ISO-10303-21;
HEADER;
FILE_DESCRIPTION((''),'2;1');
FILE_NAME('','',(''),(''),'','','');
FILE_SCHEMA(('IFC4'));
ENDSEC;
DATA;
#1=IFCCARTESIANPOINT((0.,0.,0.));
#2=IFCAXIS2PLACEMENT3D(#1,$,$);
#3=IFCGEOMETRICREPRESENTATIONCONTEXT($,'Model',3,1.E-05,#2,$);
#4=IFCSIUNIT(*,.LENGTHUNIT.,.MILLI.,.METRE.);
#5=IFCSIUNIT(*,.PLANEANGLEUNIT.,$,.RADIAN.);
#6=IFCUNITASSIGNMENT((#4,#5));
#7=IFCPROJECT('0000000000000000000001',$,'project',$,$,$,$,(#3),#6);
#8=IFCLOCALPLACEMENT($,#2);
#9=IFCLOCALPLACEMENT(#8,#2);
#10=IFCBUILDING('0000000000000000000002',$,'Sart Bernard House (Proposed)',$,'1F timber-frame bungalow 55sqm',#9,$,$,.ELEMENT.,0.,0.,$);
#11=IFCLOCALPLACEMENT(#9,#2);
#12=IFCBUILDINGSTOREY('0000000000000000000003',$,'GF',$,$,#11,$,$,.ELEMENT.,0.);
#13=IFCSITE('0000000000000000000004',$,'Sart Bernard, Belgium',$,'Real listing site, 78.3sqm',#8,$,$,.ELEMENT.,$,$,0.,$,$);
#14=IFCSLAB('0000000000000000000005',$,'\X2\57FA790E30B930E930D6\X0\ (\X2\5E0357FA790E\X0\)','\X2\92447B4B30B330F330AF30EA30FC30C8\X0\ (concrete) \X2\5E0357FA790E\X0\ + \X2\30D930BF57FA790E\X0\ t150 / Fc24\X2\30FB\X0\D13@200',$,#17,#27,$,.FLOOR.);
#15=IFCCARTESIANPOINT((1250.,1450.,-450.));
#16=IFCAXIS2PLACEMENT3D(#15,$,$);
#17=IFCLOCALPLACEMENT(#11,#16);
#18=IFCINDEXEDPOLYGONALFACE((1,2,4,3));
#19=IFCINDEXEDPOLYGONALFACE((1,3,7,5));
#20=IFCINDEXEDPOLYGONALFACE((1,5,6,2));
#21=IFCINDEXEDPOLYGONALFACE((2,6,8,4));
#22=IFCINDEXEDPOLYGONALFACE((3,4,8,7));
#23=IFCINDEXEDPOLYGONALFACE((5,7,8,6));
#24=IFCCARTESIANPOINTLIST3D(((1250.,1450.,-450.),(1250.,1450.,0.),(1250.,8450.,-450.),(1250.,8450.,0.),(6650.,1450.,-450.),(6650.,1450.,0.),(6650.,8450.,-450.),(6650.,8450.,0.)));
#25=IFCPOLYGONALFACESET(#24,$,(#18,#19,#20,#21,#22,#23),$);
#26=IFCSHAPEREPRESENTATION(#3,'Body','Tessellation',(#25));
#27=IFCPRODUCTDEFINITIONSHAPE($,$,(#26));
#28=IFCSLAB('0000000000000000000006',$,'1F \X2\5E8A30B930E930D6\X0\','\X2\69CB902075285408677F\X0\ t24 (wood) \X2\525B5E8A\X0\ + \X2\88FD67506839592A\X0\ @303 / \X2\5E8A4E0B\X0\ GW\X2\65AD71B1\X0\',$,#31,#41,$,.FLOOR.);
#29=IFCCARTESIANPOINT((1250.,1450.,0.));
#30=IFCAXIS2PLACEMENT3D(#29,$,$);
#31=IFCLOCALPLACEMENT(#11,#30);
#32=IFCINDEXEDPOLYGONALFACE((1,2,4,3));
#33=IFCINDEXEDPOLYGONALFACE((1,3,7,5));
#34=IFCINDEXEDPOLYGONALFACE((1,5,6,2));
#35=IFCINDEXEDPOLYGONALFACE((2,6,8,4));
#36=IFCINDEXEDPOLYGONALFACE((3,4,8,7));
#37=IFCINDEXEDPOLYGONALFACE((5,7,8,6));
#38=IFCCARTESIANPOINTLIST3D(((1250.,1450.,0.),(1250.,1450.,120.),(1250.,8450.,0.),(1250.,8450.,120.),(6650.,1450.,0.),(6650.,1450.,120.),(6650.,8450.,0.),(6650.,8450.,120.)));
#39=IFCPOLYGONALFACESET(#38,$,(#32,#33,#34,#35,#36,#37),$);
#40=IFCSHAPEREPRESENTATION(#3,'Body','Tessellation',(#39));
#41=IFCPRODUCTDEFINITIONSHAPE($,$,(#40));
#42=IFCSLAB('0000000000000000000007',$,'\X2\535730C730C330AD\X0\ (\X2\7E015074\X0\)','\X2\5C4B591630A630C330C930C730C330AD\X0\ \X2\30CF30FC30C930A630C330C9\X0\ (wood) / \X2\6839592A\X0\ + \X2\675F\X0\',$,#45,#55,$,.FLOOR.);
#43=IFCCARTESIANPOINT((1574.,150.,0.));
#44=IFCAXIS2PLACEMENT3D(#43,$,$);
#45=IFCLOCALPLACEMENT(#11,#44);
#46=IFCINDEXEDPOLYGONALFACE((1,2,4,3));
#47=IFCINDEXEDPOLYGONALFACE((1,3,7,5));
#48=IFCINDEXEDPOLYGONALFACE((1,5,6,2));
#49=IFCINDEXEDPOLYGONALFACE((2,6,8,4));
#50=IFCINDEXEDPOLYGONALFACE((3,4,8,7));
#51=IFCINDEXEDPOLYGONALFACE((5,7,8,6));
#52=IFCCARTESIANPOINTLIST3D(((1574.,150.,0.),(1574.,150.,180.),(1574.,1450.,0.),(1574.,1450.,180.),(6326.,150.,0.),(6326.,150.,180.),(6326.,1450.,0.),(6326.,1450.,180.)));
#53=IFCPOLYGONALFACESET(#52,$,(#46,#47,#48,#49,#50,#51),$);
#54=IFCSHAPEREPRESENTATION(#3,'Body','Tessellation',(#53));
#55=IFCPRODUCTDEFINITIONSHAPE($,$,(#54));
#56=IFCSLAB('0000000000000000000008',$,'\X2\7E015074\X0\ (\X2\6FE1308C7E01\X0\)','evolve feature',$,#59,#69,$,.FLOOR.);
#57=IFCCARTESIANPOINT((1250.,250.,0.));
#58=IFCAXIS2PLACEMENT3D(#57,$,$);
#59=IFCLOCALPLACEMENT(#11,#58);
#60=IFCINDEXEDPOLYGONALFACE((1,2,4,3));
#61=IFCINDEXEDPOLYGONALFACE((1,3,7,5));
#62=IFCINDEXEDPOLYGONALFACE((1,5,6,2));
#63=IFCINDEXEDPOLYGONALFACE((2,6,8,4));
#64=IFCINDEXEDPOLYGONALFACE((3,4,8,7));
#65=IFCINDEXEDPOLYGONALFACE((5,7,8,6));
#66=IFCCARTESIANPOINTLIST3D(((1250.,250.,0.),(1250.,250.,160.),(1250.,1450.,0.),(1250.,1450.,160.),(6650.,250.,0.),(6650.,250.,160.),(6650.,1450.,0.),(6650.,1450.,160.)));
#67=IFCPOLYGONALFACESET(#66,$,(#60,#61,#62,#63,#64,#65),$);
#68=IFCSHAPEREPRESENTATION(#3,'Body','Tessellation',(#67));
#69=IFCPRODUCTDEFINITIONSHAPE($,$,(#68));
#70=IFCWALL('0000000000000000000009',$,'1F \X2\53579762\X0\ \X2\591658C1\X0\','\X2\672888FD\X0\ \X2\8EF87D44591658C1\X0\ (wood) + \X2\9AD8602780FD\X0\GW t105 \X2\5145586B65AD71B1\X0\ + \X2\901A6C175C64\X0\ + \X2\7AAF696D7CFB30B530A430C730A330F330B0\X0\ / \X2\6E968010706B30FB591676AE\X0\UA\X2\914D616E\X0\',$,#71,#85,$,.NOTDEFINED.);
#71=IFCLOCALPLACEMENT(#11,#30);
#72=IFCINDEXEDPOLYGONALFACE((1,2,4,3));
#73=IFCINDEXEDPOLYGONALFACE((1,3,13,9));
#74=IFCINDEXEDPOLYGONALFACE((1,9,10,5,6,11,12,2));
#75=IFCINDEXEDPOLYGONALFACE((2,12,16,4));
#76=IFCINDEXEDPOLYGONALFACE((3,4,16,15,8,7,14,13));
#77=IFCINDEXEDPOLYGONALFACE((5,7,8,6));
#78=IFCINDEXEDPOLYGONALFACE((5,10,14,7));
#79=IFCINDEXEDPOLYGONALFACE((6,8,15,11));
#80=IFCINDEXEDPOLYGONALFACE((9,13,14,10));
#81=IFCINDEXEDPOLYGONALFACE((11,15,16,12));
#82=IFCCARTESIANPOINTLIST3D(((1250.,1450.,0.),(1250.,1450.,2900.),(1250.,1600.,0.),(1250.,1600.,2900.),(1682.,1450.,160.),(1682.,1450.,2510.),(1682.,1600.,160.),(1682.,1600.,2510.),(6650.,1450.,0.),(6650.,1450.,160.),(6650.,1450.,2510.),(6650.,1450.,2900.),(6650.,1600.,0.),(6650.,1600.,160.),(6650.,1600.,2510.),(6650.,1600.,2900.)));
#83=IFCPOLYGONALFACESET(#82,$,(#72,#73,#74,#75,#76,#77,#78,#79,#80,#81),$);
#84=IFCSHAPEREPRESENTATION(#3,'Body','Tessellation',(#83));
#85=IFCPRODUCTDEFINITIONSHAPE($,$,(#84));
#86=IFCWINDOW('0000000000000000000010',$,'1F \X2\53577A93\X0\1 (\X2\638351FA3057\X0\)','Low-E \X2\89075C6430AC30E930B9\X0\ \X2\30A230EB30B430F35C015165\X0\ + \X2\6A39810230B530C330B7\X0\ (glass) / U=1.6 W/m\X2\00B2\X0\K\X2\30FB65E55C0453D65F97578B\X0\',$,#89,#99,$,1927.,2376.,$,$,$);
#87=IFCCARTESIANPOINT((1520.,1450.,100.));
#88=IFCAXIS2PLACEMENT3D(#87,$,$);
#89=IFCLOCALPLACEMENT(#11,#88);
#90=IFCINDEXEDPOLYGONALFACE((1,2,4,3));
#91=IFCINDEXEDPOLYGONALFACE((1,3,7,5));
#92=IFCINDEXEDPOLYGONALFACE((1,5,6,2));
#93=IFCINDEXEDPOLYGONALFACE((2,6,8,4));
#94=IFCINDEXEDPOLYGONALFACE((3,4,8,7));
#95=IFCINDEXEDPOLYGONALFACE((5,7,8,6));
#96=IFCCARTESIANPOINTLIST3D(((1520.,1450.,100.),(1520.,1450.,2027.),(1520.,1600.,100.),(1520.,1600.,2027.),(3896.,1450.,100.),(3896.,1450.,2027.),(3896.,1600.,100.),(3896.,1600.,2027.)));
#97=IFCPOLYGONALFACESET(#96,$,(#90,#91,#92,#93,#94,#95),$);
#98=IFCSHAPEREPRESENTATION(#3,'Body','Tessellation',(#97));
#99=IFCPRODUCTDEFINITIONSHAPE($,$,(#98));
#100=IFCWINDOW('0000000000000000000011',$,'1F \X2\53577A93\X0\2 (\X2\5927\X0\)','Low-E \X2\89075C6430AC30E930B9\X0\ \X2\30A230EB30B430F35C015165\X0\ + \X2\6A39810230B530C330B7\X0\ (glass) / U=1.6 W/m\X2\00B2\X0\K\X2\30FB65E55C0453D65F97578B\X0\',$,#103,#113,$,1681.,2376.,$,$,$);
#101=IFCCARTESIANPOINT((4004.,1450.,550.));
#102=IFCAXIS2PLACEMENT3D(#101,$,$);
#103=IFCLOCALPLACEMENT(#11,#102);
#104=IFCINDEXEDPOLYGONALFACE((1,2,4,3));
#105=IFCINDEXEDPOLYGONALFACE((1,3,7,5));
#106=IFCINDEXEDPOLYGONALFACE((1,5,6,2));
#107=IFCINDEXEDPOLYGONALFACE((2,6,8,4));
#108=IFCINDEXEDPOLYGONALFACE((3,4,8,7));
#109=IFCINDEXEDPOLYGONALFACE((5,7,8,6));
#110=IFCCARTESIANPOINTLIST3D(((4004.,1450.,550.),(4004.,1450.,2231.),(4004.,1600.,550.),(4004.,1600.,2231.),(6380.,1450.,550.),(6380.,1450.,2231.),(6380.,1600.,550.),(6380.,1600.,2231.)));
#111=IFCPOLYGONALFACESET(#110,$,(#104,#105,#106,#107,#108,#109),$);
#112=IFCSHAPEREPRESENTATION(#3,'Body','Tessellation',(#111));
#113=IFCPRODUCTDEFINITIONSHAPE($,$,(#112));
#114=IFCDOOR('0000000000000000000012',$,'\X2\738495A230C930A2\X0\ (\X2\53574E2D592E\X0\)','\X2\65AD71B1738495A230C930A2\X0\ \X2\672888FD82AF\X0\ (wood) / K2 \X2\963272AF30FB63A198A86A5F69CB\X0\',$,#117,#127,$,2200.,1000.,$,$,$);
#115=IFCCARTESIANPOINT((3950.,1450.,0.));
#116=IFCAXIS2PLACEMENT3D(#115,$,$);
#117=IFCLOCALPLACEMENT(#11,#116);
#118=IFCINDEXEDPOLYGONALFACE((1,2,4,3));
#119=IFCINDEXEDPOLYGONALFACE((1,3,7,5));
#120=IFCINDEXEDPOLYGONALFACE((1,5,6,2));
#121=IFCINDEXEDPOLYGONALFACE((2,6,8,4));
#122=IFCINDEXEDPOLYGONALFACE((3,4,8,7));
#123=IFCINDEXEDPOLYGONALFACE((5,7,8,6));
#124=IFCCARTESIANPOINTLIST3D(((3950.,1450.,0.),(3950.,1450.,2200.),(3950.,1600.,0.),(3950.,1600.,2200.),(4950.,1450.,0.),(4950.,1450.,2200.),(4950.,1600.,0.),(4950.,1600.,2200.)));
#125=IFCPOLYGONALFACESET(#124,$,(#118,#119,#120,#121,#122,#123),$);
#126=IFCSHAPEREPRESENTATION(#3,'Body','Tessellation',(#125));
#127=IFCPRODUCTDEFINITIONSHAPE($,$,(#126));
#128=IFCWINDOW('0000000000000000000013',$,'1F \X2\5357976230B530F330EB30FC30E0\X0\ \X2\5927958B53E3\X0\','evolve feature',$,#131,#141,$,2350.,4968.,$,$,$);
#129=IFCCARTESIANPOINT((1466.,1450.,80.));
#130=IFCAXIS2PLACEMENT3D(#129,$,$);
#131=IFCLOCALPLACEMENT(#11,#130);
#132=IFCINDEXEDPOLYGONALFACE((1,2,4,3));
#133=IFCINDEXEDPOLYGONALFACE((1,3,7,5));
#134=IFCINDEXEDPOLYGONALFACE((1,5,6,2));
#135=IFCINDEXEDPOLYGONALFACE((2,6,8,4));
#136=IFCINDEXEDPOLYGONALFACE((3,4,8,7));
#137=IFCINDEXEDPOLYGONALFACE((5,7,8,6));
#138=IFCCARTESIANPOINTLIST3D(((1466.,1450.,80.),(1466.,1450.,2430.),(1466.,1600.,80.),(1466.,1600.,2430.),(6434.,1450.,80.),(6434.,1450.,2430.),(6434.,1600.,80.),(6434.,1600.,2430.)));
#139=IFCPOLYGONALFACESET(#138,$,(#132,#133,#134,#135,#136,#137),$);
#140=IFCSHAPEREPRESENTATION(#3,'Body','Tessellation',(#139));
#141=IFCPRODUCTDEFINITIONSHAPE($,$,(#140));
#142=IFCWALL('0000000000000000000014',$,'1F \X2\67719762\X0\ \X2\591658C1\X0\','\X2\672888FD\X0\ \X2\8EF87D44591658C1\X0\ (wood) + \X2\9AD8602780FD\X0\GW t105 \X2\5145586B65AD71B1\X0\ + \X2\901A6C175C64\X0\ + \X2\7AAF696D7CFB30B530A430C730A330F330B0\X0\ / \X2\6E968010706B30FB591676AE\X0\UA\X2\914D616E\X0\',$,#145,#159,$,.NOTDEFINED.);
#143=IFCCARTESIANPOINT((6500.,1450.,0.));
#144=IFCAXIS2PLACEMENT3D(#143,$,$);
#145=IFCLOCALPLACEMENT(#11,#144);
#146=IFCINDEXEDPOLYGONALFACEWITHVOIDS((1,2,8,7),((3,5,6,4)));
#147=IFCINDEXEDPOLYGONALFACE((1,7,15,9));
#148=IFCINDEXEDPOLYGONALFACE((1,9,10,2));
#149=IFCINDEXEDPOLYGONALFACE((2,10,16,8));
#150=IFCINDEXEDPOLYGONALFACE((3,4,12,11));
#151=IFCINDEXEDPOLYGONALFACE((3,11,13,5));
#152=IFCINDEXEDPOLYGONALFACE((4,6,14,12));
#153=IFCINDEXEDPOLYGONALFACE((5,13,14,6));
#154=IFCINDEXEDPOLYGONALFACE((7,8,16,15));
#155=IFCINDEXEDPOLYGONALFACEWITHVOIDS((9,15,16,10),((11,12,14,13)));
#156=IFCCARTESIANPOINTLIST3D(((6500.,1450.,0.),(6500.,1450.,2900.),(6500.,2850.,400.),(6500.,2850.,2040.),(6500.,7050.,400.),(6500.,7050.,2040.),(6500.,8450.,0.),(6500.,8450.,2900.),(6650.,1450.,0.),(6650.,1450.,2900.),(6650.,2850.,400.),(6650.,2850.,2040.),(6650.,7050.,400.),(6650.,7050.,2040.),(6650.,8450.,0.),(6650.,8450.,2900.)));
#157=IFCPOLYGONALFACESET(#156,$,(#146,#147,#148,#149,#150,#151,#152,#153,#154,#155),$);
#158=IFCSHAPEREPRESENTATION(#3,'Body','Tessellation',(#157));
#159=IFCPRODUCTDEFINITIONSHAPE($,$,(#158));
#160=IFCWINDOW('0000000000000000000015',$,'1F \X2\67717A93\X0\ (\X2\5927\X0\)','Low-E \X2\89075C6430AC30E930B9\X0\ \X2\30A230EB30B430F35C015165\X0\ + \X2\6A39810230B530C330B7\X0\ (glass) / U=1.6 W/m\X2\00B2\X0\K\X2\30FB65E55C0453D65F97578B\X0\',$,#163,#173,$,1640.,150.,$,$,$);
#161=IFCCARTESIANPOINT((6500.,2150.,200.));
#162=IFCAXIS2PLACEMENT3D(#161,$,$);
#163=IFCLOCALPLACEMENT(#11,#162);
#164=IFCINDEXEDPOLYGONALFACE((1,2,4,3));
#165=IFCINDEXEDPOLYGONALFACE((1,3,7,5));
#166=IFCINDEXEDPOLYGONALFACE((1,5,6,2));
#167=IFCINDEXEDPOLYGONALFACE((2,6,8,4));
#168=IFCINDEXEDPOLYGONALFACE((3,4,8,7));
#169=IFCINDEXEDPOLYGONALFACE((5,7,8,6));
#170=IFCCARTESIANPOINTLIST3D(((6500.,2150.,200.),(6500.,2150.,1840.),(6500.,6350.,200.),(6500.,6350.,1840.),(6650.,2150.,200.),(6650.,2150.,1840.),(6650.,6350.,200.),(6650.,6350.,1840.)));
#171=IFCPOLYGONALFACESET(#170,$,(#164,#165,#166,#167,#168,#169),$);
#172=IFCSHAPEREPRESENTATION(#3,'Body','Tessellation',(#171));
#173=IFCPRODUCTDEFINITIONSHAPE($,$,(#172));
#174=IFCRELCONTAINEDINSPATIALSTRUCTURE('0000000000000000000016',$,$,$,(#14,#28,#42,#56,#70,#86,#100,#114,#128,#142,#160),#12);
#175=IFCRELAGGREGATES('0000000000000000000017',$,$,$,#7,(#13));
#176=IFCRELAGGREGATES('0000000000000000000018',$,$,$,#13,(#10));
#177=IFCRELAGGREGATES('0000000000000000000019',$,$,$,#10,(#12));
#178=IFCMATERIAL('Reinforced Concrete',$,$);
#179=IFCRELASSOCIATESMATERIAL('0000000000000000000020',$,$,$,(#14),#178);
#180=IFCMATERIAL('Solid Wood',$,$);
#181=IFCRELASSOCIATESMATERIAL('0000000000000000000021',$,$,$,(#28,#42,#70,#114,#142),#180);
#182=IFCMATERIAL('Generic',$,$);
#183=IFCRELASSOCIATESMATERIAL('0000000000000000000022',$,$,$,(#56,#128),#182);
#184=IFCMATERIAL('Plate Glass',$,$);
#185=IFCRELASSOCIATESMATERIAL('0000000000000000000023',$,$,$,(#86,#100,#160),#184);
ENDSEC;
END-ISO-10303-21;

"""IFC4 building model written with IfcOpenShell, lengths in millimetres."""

from ifc_helpers import new_model, si_unit, frame, frame_2d, origin, place, context, project, spatial, rectangle, extrude, material, element, fill, save


model = new_model("IFC4")

# Units and contexts
model_context = context("Model", 3, precision=1e-05, world=origin())
ifc_project = project(units=[si_unit("LENGTHUNIT", "METRE", prefix="MILLI"), si_unit("PLANEANGLEUNIT", "RADIAN")], contexts=[model_context])

# Site, building, storey
site_placement = place(None, origin())
site = spatial("IfcSite", under=ifc_project, at=site_placement, Name="Sart Bernard, Belgium", ObjectType="Real listing site, 78.3sqm", CompositionType="ELEMENT", RefElevation=0.0)
building_placement = place(site_placement, origin())
building = spatial("IfcBuilding", under=site, at=building_placement, Name="Sart Bernard House (Proposed)", ObjectType="1F timber-frame bungalow 55sqm", CompositionType="ELEMENT", ElevationOfRefHeight=0.0, ElevationOfTerrain=0.0)
storey_placement = place(building_placement, origin())
storey = spatial("IfcBuildingStorey", under=building, at=storey_placement, Name="GF", CompositionType="ELEMENT", Elevation=0.0)

# Slabs
ifc_material_1 = material(Name="Reinforced Concrete")
slab_1_placement = place(storey_placement, frame((1250.0, 1450.0, -450.0)))
element("IfcSlab", 1, at=slab_1_placement, inside=storey, material=ifc_material_1, Name="基礎スラブ (布基礎)", Description="鉄筋コンクリート (concrete) 布基礎 + ベタ基礎 t150 / Fc24・D13@200", PredefinedType="FLOOR", context=model_context, shape_type="SweptSolid", body=[
    extrude(rectangle(XDim=5400.0, YDim=7000.0, at=frame_2d((2700.0, 3500.0))), frame((1250.0, 1450.0, -450.0)), (0.0, 0.0, 1.0), 450.0),
])
ifc_material_2 = material(Name="Solid Wood")
slab_2_placement = place(storey_placement, frame((1250.0, 1450.0, 0.0)))
element("IfcSlab", 2, at=slab_2_placement, inside=storey, material=ifc_material_2, Name="1F 床スラブ", Description="構造用合板 t24 (wood) 剛床 + 製材根太 @303 / 床下 GW断熱", PredefinedType="FLOOR", context=model_context, shape_type="SweptSolid", body=[
    extrude(rectangle(XDim=5400.0, YDim=7000.0, at=frame_2d((2700.0, 3500.0))), frame((1250.0, 1450.0, 0.0)), (0.0, 0.0, 1.0), 120.0),
])
slab_3_placement = place(storey_placement, frame((1574.0, 150.0, 0.0)))
element("IfcSlab", 3, at=slab_3_placement, inside=storey, material=ifc_material_2, Name="南デッキ (縁側)", Description="屋外ウッドデッキ ハードウッド (wood) / 根太 + 束", PredefinedType="FLOOR", context=model_context, shape_type="SweptSolid", body=[
    extrude(rectangle(XDim=4752.0, YDim=1300.0, at=frame_2d((2376.0, 650.0))), frame((1574.0, 150.0, 0.0)), (0.0, 0.0, 1.0), 180.0),
])
ifc_material_3 = material(Name="Generic")
slab_4_placement = place(storey_placement, frame((1250.0, 250.0, 0.0)))
element("IfcSlab", 4, at=slab_4_placement, inside=storey, material=ifc_material_3, Name="縁側 (濡れ縁)", Description="evolve feature", PredefinedType="FLOOR", context=model_context, shape_type="SweptSolid", body=[
    extrude(rectangle(XDim=5400.0, YDim=1200.0, at=frame_2d((2700.0, 600.0))), frame((1250.0, 250.0, 0.0)), (0.0, 0.0, 1.0), 160.0),
])

# Wall, openings, windows, door
wall_1_placement = place(storey_placement, frame((1250.0, 1450.0, 0.0)))
wall_1 = element("IfcWall", 5, at=wall_1_placement, inside=storey, material=ifc_material_2, Name="1F 南面 外壁", Description="木製 軸組外壁 (wood) + 高性能GW t105 充填断熱 + 通気層 + 窯業系サイディング / 準耐火・外皮UA配慮", PredefinedType="NOTDEFINED", context=model_context, shape_type="SweptSolid", body=[
    extrude(rectangle(XDim=5400.0, YDim=150.0, at=frame_2d((2700.0, 75.0))), frame((1250.0, 1450.0, 0.0)), (0.0, 0.0, 1.0), 2900.0),
])
opening_1_placement = place(storey_placement, frame((1520.0, 1450.0, 100.0)))
opening_1 = element("IfcOpeningElement", 6, at=opening_1_placement, cuts=wall_1, PredefinedType="NOTDEFINED", context=model_context, shape_type="SweptSolid", body=[
    extrude(rectangle(XDim=2376.0, YDim=150.0, at=frame_2d((1188.0, 75.0))), frame((1520.0, 1450.0, 100.0)), (0.0, 0.0, 1.0), 1927.0),
])
opening_2_placement = place(storey_placement, frame((4004.0, 1450.0, 550.0)))
opening_2 = element("IfcOpeningElement", 7, at=opening_2_placement, cuts=wall_1, PredefinedType="NOTDEFINED", context=model_context, shape_type="SweptSolid", body=[
    extrude(rectangle(XDim=2376.0, YDim=150.0, at=frame_2d((1188.0, 75.0))), frame((4004.0, 1450.0, 550.0)), (0.0, 0.0, 1.0), 1681.0),
])
opening_3_placement = place(storey_placement, frame((3950.0, 1450.0, 0.0)))
opening_3 = element("IfcOpeningElement", 8, at=opening_3_placement, cuts=wall_1, PredefinedType="NOTDEFINED", context=model_context, shape_type="SweptSolid", body=[
    extrude(rectangle(XDim=1000.0, YDim=150.0, at=frame_2d((500.0, 75.0))), frame((3950.0, 1450.0, 0.0)), (0.0, 0.0, 1.0), 2200.0),
])
opening_4_placement = place(storey_placement, frame((1466.0, 1450.0, 80.0)))
opening_4 = element("IfcOpeningElement", 9, at=opening_4_placement, cuts=wall_1, PredefinedType="NOTDEFINED", context=model_context, shape_type="SweptSolid", body=[
    extrude(rectangle(XDim=4968.0, YDim=150.0, at=frame_2d((2484.0, 75.0))), frame((1466.0, 1450.0, 80.0)), (0.0, 0.0, 1.0), 2350.0),
])
ifc_material_4 = material(Name="Plate Glass")
window_1_placement = place(storey_placement, frame((1520.0, 1450.0, 100.0)))
window_1 = element("IfcWindow", 10, at=window_1_placement, inside=storey, material=ifc_material_4, Name="1F 南窓1 (掃出し)", Description="Low-E 複層ガラス アルゴン封入 + 樹脂サッシ (glass) / U=1.6 W/m²K・日射取得型", OverallHeight=1927.0, OverallWidth=2376.0, context=model_context, shape_type="SweptSolid", body=[
    extrude(rectangle(XDim=2376.0, YDim=150.0, at=frame_2d((1188.0, 75.0))), frame((1520.0, 1450.0, 100.0)), (0.0, 0.0, 1.0), 1927.0),
])
fill(opening_1, window_1)
window_2_placement = place(storey_placement, frame((4004.0, 1450.0, 550.0)))
window_2 = element("IfcWindow", 11, at=window_2_placement, inside=storey, material=ifc_material_4, Name="1F 南窓2 (大)", Description="Low-E 複層ガラス アルゴン封入 + 樹脂サッシ (glass) / U=1.6 W/m²K・日射取得型", OverallHeight=1681.0, OverallWidth=2376.0, context=model_context, shape_type="SweptSolid", body=[
    extrude(rectangle(XDim=2376.0, YDim=150.0, at=frame_2d((1188.0, 75.0))), frame((4004.0, 1450.0, 550.0)), (0.0, 0.0, 1.0), 1681.0),
])
fill(opening_2, window_2)
door_placement = place(storey_placement, frame((3950.0, 1450.0, 0.0)))
door = element("IfcDoor", 12, at=door_placement, inside=storey, material=ifc_material_2, Name="玄関ドア (南中央)", Description="断熱玄関ドア 木製芯 (wood) / K2 防犯・採風機構", OverallHeight=2200.0, OverallWidth=1000.0, context=model_context, shape_type="SweptSolid", body=[
    extrude(rectangle(XDim=1000.0, YDim=150.0, at=frame_2d((500.0, 75.0))), frame((3950.0, 1450.0, 0.0)), (0.0, 0.0, 1.0), 2200.0),
])
fill(opening_3, door)
window_3_placement = place(storey_placement, frame((1466.0, 1450.0, 80.0)))
window_3 = element("IfcWindow", 13, at=window_3_placement, inside=storey, material=ifc_material_3, Name="1F 南面サンルーム 大開口", Description="evolve feature", OverallHeight=2350.0, OverallWidth=4968.0, context=model_context, shape_type="SweptSolid", body=[
    extrude(rectangle(XDim=4968.0, YDim=150.0, at=frame_2d((2484.0, 75.0))), frame((1466.0, 1450.0, 80.0)), (0.0, 0.0, 1.0), 2350.0),
])
fill(opening_4, window_3)

# Wall, opening, window
wall_2_placement = place(storey_placement, frame((6500.0, 1450.0, 0.0)))
wall_2 = element("IfcWall", 14, at=wall_2_placement, inside=storey, material=ifc_material_2, Name="1F 東面 外壁", Description="木製 軸組外壁 (wood) + 高性能GW t105 充填断熱 + 通気層 + 窯業系サイディング / 準耐火・外皮UA配慮", PredefinedType="NOTDEFINED", context=model_context, shape_type="SweptSolid", body=[
    extrude(rectangle(XDim=150.0, YDim=7000.0, at=frame_2d((75.0, 3500.0))), frame((6500.0, 1450.0, 0.0)), (0.0, 0.0, 1.0), 2900.0),
])
opening_5_placement = place(storey_placement, frame((6500.0, 2150.0, 200.0)))
opening_5 = element("IfcOpeningElement", 15, at=opening_5_placement, cuts=wall_2, PredefinedType="NOTDEFINED", context=model_context, shape_type="SweptSolid", body=[
    extrude(rectangle(XDim=150.0, YDim=4200.0, at=frame_2d((75.0, 2100.0))), frame((6500.0, 2150.0, 200.0)), (0.0, 0.0, 1.0), 1640.0),
])
window_4_placement = place(storey_placement, frame((6500.0, 2150.0, 200.0)))
window_4 = element("IfcWindow", 16, at=window_4_placement, inside=storey, material=ifc_material_4, Name="1F 東窓 (大)", Description="Low-E 複層ガラス アルゴン封入 + 樹脂サッシ (glass) / U=1.6 W/m²K・日射取得型", OverallHeight=1640.0, OverallWidth=150.0, context=model_context, shape_type="SweptSolid", body=[
    extrude(rectangle(XDim=150.0, YDim=4200.0, at=frame_2d((75.0, 2100.0))), frame((6500.0, 2150.0, 200.0)), (0.0, 0.0, 1.0), 1640.0),
])
fill(opening_5, window_4)

save(model, "model.ifc")
